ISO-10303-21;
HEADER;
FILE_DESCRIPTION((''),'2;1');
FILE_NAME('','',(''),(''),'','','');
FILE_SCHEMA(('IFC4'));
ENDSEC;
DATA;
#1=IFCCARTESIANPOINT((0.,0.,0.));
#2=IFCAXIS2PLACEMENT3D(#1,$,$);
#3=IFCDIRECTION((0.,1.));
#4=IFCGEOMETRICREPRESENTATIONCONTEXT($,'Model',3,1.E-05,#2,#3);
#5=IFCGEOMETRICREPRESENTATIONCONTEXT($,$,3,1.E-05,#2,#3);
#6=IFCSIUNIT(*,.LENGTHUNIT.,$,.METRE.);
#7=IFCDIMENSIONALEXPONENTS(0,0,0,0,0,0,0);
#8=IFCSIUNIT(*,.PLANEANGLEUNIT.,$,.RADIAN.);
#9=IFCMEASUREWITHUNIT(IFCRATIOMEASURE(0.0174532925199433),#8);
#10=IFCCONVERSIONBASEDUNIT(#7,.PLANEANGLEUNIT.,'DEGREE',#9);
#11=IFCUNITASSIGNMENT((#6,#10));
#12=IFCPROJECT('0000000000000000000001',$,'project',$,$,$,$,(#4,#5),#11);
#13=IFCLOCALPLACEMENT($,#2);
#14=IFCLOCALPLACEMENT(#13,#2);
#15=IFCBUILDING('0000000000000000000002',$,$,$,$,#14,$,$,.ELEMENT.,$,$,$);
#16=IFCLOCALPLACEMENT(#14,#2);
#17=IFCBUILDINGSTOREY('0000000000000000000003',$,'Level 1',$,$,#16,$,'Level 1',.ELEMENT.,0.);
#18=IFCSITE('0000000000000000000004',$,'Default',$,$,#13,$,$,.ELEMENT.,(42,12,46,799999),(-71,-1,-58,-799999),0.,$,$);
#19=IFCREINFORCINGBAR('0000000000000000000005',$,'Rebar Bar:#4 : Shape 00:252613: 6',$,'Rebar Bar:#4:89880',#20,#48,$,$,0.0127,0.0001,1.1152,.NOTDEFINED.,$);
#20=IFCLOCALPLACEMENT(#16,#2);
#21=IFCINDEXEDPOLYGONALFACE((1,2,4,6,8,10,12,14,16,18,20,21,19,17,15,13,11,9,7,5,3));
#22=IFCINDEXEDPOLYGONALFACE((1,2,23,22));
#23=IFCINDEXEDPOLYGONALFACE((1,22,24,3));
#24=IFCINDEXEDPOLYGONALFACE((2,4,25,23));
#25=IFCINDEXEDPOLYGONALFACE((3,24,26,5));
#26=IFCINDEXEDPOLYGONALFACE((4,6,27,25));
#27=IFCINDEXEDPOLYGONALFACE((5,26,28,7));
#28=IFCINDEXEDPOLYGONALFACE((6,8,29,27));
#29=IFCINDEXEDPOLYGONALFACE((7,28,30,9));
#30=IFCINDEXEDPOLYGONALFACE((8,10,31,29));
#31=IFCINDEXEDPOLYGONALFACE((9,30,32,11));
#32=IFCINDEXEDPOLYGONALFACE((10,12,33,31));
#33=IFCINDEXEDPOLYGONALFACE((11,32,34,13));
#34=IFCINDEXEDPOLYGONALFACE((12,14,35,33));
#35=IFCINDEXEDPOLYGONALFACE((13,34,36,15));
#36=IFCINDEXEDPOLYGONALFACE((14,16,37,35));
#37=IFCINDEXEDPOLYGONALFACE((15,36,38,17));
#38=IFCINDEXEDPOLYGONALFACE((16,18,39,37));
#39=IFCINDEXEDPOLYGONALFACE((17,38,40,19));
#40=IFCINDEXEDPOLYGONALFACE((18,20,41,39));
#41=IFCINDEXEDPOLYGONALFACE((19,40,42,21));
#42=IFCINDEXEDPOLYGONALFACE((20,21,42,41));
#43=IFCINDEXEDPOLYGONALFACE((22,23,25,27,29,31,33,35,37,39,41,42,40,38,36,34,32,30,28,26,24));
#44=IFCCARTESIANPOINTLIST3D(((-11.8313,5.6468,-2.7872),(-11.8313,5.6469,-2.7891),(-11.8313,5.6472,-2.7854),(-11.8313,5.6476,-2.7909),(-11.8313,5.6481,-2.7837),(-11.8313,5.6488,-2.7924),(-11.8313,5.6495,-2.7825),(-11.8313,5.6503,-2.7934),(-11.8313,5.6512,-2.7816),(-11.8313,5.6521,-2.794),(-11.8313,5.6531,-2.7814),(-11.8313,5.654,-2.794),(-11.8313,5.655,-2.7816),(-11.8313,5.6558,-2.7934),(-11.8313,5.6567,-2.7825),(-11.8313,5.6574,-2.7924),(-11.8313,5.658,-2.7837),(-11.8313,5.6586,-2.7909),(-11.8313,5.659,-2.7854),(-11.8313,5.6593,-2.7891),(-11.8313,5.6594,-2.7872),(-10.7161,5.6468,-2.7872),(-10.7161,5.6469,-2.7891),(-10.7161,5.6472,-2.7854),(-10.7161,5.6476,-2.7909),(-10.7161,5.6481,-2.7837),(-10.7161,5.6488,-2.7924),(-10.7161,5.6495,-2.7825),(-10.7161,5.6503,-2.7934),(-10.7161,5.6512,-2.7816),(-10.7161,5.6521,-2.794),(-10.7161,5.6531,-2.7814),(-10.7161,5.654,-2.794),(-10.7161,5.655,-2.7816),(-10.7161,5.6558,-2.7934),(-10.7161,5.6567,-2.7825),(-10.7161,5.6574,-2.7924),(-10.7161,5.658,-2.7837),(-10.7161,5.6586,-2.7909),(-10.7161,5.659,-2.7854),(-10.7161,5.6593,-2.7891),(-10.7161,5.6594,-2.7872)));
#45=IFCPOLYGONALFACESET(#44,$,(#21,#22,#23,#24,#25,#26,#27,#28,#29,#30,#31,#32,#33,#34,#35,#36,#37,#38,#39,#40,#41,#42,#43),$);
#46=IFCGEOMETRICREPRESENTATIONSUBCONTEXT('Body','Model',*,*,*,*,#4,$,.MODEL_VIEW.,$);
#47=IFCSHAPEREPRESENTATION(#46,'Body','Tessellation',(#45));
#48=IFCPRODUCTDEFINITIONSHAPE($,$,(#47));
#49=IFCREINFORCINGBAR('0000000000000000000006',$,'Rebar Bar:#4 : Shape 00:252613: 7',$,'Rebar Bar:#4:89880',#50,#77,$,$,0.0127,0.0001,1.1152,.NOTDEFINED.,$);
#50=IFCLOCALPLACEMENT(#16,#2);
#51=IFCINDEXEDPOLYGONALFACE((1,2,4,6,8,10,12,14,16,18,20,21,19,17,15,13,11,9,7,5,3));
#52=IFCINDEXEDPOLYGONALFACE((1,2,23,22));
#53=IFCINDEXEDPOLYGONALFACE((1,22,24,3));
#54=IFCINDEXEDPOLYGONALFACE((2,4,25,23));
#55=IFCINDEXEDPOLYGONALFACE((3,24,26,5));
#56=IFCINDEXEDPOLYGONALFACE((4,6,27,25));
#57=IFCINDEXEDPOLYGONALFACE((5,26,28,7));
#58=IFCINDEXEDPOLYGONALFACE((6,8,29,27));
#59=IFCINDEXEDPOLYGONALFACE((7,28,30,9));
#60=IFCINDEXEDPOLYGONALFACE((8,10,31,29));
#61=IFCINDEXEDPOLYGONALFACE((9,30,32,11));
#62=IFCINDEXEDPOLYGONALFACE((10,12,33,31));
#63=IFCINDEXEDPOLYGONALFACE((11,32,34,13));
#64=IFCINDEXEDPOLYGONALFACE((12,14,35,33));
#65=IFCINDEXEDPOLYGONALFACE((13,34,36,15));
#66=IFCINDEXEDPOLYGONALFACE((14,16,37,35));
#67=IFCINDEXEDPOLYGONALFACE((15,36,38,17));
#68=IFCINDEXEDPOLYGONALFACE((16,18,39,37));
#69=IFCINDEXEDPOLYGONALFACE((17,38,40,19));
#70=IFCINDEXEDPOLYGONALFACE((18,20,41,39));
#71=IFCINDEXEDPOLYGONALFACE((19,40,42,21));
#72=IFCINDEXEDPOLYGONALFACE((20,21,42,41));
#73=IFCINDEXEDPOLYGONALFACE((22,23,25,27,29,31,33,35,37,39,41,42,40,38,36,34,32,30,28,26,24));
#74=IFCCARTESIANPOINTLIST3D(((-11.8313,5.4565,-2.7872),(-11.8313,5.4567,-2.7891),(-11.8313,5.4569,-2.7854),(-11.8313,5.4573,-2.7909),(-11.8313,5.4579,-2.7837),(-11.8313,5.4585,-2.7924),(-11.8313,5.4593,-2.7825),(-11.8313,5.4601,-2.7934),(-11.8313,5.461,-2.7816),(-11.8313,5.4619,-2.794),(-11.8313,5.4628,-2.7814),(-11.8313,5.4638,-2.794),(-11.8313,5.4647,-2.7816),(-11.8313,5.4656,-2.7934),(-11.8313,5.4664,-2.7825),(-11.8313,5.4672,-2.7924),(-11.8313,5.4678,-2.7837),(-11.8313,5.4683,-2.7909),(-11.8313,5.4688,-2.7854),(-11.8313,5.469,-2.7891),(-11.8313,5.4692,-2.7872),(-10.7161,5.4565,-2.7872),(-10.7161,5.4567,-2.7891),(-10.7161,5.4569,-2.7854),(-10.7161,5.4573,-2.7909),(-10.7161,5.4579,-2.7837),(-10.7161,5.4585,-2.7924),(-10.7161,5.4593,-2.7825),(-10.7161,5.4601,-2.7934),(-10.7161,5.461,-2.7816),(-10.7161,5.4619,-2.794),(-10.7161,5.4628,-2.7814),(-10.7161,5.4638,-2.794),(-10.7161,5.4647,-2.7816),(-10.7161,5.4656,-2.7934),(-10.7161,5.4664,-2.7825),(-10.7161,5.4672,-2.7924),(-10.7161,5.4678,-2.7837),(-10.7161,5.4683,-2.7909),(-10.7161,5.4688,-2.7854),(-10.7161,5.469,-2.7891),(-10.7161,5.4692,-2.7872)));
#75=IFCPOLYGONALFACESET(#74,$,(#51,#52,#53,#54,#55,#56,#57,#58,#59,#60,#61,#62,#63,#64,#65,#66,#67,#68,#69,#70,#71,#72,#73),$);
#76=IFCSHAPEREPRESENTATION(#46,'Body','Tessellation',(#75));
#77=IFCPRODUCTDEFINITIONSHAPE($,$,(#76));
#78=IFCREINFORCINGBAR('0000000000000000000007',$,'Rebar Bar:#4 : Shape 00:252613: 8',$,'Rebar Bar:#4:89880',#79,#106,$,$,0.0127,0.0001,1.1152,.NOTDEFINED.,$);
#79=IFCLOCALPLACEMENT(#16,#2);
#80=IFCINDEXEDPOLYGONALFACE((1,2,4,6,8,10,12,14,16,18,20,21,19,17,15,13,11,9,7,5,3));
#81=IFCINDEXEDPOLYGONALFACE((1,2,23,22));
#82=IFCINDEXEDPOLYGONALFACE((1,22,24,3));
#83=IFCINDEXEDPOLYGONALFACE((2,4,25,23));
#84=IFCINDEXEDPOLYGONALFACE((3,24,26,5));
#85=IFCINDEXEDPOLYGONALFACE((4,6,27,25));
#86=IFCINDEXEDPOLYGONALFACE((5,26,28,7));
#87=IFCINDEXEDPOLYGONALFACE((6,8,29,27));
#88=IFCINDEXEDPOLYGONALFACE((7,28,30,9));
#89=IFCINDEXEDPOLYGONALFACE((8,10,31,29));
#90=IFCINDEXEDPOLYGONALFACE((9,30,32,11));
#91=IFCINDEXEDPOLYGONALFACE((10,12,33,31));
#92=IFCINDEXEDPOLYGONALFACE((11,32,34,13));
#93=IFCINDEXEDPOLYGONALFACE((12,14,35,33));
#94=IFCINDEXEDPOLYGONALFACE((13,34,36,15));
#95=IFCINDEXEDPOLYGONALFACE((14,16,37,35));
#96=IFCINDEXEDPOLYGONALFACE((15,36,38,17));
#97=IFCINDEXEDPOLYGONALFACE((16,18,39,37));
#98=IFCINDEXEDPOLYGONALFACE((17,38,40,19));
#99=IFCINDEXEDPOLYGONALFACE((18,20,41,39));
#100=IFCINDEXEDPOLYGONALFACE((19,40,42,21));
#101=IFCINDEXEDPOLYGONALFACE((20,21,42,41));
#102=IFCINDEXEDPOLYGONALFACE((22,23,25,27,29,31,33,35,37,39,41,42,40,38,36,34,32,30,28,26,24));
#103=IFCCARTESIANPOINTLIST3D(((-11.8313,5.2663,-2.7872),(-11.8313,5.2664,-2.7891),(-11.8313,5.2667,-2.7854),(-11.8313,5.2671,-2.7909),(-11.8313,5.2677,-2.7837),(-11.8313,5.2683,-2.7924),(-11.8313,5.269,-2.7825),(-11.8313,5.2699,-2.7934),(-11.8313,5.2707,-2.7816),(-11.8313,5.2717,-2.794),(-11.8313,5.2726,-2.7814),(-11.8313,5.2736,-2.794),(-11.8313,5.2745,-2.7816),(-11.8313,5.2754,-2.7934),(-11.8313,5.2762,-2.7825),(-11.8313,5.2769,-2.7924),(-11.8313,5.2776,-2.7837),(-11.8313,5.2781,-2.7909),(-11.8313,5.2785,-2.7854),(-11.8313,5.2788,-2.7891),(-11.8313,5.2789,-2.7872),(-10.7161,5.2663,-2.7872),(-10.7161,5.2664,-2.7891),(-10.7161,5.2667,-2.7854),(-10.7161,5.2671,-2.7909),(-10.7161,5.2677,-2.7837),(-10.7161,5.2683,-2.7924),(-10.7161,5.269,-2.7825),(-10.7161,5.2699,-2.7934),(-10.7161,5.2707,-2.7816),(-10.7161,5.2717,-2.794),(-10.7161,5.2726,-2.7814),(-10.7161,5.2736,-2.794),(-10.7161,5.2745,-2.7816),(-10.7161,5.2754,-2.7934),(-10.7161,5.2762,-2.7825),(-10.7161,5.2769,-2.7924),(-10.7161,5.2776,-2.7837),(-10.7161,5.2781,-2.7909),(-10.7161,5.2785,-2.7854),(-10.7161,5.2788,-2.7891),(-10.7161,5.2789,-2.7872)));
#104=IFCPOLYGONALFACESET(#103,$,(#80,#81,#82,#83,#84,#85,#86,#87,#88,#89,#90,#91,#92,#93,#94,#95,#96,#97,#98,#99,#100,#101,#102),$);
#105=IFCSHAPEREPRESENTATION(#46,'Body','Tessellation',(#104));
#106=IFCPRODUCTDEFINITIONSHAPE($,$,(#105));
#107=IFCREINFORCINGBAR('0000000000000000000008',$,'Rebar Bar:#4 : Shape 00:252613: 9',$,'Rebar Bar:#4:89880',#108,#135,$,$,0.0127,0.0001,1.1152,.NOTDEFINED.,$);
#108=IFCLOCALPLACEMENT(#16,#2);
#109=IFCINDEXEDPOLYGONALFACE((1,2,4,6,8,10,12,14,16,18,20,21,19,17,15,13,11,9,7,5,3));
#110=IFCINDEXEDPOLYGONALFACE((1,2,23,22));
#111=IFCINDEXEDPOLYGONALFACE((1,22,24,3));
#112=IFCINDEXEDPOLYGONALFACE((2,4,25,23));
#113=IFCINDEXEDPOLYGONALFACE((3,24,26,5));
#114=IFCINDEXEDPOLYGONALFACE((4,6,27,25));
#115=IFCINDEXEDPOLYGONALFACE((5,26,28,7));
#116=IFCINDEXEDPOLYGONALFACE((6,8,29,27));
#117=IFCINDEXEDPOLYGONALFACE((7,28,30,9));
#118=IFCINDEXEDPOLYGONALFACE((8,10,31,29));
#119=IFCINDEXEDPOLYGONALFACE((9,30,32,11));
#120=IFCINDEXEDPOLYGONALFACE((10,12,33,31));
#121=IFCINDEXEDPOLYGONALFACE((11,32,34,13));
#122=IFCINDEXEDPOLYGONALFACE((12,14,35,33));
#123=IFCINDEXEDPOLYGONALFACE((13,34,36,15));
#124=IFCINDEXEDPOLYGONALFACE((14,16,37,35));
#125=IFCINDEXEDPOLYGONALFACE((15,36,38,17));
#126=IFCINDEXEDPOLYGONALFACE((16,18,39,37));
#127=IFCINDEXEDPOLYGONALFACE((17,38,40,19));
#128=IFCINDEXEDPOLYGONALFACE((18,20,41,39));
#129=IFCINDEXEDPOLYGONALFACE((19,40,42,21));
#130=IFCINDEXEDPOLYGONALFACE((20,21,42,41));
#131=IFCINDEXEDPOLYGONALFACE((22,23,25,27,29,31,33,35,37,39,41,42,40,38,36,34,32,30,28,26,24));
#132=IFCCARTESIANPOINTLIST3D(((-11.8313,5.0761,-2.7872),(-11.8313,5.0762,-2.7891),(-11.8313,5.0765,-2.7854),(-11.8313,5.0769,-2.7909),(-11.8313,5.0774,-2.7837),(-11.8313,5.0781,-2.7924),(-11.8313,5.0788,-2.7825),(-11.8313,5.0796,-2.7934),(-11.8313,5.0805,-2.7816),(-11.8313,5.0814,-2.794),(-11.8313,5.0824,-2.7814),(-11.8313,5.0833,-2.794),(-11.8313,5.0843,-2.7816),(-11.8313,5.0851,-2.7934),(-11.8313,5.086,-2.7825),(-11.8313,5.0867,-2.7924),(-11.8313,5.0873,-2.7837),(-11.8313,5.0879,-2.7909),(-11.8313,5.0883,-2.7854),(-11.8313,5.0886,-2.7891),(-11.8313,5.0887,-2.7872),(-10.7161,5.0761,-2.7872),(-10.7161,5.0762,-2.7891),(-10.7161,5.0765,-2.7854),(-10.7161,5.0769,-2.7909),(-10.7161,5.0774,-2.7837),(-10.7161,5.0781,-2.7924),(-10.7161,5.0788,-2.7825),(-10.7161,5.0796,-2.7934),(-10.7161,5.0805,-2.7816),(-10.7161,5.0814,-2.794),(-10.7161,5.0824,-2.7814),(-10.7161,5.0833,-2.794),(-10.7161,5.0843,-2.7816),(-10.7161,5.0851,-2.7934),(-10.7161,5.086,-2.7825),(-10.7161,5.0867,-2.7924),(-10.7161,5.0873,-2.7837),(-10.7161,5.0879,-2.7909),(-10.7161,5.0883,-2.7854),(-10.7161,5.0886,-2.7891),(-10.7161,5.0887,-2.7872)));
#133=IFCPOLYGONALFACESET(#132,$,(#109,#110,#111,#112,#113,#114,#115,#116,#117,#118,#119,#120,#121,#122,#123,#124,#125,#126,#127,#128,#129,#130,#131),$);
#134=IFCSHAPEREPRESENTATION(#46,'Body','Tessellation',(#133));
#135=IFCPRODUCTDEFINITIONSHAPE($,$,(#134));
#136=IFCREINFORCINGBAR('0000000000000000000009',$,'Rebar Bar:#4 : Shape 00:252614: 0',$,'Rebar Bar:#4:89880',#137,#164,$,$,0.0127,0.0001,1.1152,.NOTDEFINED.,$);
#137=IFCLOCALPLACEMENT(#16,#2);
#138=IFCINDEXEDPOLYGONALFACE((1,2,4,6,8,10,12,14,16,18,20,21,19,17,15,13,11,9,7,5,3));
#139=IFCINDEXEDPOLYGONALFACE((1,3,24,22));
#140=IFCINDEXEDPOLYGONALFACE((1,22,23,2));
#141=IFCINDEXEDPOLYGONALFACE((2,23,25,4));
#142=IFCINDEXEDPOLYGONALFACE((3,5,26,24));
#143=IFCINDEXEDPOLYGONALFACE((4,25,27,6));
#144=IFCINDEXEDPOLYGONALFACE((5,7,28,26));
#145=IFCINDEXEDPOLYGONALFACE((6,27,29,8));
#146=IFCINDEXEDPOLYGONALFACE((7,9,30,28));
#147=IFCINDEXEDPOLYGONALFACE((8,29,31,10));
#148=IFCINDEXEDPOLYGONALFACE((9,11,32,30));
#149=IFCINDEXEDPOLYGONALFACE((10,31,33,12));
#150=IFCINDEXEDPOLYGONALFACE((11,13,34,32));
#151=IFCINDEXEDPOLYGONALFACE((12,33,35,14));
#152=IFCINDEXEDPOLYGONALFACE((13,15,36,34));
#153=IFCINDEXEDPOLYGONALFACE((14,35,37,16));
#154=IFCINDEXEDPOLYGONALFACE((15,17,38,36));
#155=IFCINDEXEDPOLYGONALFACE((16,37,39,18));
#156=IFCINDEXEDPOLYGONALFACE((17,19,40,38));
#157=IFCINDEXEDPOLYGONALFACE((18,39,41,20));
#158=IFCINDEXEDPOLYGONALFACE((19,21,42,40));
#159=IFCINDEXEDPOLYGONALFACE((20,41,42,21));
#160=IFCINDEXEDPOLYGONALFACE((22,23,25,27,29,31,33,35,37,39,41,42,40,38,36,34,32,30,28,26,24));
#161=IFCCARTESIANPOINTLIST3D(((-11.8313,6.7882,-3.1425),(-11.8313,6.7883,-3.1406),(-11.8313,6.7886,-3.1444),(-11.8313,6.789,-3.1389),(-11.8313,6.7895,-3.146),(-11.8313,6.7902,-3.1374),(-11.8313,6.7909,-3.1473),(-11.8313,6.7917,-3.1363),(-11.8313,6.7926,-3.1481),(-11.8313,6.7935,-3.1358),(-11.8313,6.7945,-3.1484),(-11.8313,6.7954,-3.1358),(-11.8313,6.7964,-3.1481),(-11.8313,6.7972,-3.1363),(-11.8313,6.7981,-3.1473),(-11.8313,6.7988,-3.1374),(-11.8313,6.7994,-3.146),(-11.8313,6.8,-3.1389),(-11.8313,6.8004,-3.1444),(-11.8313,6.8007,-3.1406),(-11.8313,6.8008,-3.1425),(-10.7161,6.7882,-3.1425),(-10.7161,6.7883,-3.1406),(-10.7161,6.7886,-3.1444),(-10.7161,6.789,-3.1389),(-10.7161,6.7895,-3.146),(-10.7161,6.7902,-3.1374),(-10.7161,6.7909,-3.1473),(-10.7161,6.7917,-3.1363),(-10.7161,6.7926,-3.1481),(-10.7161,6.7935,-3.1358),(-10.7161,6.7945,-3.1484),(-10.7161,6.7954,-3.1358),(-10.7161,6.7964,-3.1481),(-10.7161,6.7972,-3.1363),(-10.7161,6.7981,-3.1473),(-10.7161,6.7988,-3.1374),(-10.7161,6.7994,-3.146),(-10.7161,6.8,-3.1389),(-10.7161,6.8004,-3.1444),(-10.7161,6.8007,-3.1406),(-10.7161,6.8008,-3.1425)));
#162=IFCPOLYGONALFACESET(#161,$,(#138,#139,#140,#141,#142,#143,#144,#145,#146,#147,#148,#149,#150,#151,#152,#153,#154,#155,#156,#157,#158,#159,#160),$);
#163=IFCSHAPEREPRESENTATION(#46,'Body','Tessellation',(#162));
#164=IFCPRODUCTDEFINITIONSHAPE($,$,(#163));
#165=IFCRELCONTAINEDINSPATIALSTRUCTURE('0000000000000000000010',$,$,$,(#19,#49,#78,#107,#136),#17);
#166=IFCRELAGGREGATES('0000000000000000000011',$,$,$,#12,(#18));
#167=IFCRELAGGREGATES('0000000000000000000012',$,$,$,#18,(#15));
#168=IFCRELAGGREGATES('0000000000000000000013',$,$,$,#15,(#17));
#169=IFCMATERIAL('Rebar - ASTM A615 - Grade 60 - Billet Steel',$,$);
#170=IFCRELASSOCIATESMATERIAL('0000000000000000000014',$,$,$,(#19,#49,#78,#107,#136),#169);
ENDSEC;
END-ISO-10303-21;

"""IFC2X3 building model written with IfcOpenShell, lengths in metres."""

from ifc_helpers import new_model, entity, si_unit, converted_unit, direction, origin, place, context, subcontext, project, spatial, material, element, save


model = new_model("IFC2X3")

# Units and contexts
model_context = context("Model", 3, precision=1e-05, world=origin(), true_north=direction((0.0, 1.0)))
context_of_model = context(None, 3, precision=1e-05, world=origin(), true_north=direction((0.0, 1.0)))
body_context = subcontext(model_context, "Body", "Model", "MODEL_VIEW")
ifc_project = project(units=[si_unit("LENGTHUNIT", "METRE"), converted_unit("PLANEANGLEUNIT", "DEGREE", entity("IfcRatioMeasure", 0.0174532925199433), si_unit("PLANEANGLEUNIT", "RADIAN"), dimensions=[0, 0, 0, 0, 0, 0, 0])], contexts=[model_context, context_of_model])

# Site, building, storey
site_placement = place(None, origin())
site = spatial("IfcSite", under=ifc_project, at=site_placement, Name="Default", CompositionType="ELEMENT", RefLatitude=(42, 12, 46, 799999), RefLongitude=(-71, -1, -58, -799999), RefElevation=0.0)
building_placement = place(site_placement, origin())
building = spatial("IfcBuilding", under=site, at=building_placement, CompositionType="ELEMENT")
storey_placement = place(building_placement, origin())
storey = spatial("IfcBuildingStorey", under=building, at=storey_placement, Name="Level 1", LongName="Level 1", CompositionType="ELEMENT", Elevation=0.0)

# Reinforcing bars
ifc_material_1 = material(Name="Rebar - ASTM A615 - Grade 60 - Billet Steel")
reinforcing_bar_1_placement = place(storey_placement, origin())
element("IfcReinforcingBar", 1, at=reinforcing_bar_1_placement, inside=storey, material=ifc_material_1, Name="Rebar Bar:#4 : Shape 00:252613: 6", ObjectType="Rebar Bar:#4:89880", BarLength=1.1152, BarRole="NOTDEFINED", CrossSectionArea=0.0001, NominalDiameter=0.0127, context=body_context, shape_type="AdvancedSweptSolid", body=[
    entity("IfcSweptDiskSolid", entity("IfcCompositeCurve", [entity("IfcCompositeCurveSegment", "CONTINUOUS", True, entity("IfcPolyline", [entity("IfcCartesianPoint", [-11.8313, 5.6531, -2.7877]), entity("IfcCartesianPoint", [-10.7161, 5.6531, -2.7877])]))], False), 0.0063, None, 0.0, 1.0),
])
reinforcing_bar_2_placement = place(storey_placement, origin())
element("IfcReinforcingBar", 2, at=reinforcing_bar_2_placement, inside=storey, material=ifc_material_1, Name="Rebar Bar:#4 : Shape 00:252613: 7", ObjectType="Rebar Bar:#4:89880", BarLength=1.1152, BarRole="NOTDEFINED", CrossSectionArea=0.0001, NominalDiameter=0.0127, context=body_context, shape_type="AdvancedSweptSolid", body=[
    entity("IfcSweptDiskSolid", entity("IfcCompositeCurve", [entity("IfcCompositeCurveSegment", "CONTINUOUS", True, entity("IfcPolyline", [entity("IfcCartesianPoint", [-11.8313, 5.4628, -2.7877]), entity("IfcCartesianPoint", [-10.7161, 5.4628, -2.7877])]))], False), 0.0063, None, 0.0, 1.0),
])
reinforcing_bar_3_placement = place(storey_placement, origin())
element("IfcReinforcingBar", 3, at=reinforcing_bar_3_placement, inside=storey, material=ifc_material_1, Name="Rebar Bar:#4 : Shape 00:252613: 8", ObjectType="Rebar Bar:#4:89880", BarLength=1.1152, BarRole="NOTDEFINED", CrossSectionArea=0.0001, NominalDiameter=0.0127, context=body_context, shape_type="AdvancedSweptSolid", body=[
    entity("IfcSweptDiskSolid", entity("IfcCompositeCurve", [entity("IfcCompositeCurveSegment", "CONTINUOUS", True, entity("IfcPolyline", [entity("IfcCartesianPoint", [-11.8313, 5.2726, -2.7877]), entity("IfcCartesianPoint", [-10.7161, 5.2726, -2.7877])]))], False), 0.0063, None, 0.0, 1.0),
])
reinforcing_bar_4_placement = place(storey_placement, origin())
element("IfcReinforcingBar", 4, at=reinforcing_bar_4_placement, inside=storey, material=ifc_material_1, Name="Rebar Bar:#4 : Shape 00:252613: 9", ObjectType="Rebar Bar:#4:89880", BarLength=1.1152, BarRole="NOTDEFINED", CrossSectionArea=0.0001, NominalDiameter=0.0127, context=body_context, shape_type="AdvancedSweptSolid", body=[
    entity("IfcSweptDiskSolid", entity("IfcCompositeCurve", [entity("IfcCompositeCurveSegment", "CONTINUOUS", True, entity("IfcPolyline", [entity("IfcCartesianPoint", [-11.8313, 5.0824, -2.7877]), entity("IfcCartesianPoint", [-10.7161, 5.0824, -2.7877])]))], False), 0.0063, None, 0.0, 1.0),
])
reinforcing_bar_5_placement = place(storey_placement, origin())
element("IfcReinforcingBar", 5, at=reinforcing_bar_5_placement, inside=storey, material=ifc_material_1, Name="Rebar Bar:#4 : Shape 00:252614: 0", ObjectType="Rebar Bar:#4:89880", BarLength=1.1152, BarRole="NOTDEFINED", CrossSectionArea=0.0001, NominalDiameter=0.0127, context=body_context, shape_type="AdvancedSweptSolid", body=[
    entity("IfcSweptDiskSolid", entity("IfcCompositeCurve", [entity("IfcCompositeCurveSegment", "CONTINUOUS", True, entity("IfcPolyline", [entity("IfcCartesianPoint", [-10.7161, 6.7945, -3.142]), entity("IfcCartesianPoint", [-11.8313, 6.7945, -3.142])]))], False), 0.0063, None, 0.0, 1.0),
])

save(model, "model.ifc")
